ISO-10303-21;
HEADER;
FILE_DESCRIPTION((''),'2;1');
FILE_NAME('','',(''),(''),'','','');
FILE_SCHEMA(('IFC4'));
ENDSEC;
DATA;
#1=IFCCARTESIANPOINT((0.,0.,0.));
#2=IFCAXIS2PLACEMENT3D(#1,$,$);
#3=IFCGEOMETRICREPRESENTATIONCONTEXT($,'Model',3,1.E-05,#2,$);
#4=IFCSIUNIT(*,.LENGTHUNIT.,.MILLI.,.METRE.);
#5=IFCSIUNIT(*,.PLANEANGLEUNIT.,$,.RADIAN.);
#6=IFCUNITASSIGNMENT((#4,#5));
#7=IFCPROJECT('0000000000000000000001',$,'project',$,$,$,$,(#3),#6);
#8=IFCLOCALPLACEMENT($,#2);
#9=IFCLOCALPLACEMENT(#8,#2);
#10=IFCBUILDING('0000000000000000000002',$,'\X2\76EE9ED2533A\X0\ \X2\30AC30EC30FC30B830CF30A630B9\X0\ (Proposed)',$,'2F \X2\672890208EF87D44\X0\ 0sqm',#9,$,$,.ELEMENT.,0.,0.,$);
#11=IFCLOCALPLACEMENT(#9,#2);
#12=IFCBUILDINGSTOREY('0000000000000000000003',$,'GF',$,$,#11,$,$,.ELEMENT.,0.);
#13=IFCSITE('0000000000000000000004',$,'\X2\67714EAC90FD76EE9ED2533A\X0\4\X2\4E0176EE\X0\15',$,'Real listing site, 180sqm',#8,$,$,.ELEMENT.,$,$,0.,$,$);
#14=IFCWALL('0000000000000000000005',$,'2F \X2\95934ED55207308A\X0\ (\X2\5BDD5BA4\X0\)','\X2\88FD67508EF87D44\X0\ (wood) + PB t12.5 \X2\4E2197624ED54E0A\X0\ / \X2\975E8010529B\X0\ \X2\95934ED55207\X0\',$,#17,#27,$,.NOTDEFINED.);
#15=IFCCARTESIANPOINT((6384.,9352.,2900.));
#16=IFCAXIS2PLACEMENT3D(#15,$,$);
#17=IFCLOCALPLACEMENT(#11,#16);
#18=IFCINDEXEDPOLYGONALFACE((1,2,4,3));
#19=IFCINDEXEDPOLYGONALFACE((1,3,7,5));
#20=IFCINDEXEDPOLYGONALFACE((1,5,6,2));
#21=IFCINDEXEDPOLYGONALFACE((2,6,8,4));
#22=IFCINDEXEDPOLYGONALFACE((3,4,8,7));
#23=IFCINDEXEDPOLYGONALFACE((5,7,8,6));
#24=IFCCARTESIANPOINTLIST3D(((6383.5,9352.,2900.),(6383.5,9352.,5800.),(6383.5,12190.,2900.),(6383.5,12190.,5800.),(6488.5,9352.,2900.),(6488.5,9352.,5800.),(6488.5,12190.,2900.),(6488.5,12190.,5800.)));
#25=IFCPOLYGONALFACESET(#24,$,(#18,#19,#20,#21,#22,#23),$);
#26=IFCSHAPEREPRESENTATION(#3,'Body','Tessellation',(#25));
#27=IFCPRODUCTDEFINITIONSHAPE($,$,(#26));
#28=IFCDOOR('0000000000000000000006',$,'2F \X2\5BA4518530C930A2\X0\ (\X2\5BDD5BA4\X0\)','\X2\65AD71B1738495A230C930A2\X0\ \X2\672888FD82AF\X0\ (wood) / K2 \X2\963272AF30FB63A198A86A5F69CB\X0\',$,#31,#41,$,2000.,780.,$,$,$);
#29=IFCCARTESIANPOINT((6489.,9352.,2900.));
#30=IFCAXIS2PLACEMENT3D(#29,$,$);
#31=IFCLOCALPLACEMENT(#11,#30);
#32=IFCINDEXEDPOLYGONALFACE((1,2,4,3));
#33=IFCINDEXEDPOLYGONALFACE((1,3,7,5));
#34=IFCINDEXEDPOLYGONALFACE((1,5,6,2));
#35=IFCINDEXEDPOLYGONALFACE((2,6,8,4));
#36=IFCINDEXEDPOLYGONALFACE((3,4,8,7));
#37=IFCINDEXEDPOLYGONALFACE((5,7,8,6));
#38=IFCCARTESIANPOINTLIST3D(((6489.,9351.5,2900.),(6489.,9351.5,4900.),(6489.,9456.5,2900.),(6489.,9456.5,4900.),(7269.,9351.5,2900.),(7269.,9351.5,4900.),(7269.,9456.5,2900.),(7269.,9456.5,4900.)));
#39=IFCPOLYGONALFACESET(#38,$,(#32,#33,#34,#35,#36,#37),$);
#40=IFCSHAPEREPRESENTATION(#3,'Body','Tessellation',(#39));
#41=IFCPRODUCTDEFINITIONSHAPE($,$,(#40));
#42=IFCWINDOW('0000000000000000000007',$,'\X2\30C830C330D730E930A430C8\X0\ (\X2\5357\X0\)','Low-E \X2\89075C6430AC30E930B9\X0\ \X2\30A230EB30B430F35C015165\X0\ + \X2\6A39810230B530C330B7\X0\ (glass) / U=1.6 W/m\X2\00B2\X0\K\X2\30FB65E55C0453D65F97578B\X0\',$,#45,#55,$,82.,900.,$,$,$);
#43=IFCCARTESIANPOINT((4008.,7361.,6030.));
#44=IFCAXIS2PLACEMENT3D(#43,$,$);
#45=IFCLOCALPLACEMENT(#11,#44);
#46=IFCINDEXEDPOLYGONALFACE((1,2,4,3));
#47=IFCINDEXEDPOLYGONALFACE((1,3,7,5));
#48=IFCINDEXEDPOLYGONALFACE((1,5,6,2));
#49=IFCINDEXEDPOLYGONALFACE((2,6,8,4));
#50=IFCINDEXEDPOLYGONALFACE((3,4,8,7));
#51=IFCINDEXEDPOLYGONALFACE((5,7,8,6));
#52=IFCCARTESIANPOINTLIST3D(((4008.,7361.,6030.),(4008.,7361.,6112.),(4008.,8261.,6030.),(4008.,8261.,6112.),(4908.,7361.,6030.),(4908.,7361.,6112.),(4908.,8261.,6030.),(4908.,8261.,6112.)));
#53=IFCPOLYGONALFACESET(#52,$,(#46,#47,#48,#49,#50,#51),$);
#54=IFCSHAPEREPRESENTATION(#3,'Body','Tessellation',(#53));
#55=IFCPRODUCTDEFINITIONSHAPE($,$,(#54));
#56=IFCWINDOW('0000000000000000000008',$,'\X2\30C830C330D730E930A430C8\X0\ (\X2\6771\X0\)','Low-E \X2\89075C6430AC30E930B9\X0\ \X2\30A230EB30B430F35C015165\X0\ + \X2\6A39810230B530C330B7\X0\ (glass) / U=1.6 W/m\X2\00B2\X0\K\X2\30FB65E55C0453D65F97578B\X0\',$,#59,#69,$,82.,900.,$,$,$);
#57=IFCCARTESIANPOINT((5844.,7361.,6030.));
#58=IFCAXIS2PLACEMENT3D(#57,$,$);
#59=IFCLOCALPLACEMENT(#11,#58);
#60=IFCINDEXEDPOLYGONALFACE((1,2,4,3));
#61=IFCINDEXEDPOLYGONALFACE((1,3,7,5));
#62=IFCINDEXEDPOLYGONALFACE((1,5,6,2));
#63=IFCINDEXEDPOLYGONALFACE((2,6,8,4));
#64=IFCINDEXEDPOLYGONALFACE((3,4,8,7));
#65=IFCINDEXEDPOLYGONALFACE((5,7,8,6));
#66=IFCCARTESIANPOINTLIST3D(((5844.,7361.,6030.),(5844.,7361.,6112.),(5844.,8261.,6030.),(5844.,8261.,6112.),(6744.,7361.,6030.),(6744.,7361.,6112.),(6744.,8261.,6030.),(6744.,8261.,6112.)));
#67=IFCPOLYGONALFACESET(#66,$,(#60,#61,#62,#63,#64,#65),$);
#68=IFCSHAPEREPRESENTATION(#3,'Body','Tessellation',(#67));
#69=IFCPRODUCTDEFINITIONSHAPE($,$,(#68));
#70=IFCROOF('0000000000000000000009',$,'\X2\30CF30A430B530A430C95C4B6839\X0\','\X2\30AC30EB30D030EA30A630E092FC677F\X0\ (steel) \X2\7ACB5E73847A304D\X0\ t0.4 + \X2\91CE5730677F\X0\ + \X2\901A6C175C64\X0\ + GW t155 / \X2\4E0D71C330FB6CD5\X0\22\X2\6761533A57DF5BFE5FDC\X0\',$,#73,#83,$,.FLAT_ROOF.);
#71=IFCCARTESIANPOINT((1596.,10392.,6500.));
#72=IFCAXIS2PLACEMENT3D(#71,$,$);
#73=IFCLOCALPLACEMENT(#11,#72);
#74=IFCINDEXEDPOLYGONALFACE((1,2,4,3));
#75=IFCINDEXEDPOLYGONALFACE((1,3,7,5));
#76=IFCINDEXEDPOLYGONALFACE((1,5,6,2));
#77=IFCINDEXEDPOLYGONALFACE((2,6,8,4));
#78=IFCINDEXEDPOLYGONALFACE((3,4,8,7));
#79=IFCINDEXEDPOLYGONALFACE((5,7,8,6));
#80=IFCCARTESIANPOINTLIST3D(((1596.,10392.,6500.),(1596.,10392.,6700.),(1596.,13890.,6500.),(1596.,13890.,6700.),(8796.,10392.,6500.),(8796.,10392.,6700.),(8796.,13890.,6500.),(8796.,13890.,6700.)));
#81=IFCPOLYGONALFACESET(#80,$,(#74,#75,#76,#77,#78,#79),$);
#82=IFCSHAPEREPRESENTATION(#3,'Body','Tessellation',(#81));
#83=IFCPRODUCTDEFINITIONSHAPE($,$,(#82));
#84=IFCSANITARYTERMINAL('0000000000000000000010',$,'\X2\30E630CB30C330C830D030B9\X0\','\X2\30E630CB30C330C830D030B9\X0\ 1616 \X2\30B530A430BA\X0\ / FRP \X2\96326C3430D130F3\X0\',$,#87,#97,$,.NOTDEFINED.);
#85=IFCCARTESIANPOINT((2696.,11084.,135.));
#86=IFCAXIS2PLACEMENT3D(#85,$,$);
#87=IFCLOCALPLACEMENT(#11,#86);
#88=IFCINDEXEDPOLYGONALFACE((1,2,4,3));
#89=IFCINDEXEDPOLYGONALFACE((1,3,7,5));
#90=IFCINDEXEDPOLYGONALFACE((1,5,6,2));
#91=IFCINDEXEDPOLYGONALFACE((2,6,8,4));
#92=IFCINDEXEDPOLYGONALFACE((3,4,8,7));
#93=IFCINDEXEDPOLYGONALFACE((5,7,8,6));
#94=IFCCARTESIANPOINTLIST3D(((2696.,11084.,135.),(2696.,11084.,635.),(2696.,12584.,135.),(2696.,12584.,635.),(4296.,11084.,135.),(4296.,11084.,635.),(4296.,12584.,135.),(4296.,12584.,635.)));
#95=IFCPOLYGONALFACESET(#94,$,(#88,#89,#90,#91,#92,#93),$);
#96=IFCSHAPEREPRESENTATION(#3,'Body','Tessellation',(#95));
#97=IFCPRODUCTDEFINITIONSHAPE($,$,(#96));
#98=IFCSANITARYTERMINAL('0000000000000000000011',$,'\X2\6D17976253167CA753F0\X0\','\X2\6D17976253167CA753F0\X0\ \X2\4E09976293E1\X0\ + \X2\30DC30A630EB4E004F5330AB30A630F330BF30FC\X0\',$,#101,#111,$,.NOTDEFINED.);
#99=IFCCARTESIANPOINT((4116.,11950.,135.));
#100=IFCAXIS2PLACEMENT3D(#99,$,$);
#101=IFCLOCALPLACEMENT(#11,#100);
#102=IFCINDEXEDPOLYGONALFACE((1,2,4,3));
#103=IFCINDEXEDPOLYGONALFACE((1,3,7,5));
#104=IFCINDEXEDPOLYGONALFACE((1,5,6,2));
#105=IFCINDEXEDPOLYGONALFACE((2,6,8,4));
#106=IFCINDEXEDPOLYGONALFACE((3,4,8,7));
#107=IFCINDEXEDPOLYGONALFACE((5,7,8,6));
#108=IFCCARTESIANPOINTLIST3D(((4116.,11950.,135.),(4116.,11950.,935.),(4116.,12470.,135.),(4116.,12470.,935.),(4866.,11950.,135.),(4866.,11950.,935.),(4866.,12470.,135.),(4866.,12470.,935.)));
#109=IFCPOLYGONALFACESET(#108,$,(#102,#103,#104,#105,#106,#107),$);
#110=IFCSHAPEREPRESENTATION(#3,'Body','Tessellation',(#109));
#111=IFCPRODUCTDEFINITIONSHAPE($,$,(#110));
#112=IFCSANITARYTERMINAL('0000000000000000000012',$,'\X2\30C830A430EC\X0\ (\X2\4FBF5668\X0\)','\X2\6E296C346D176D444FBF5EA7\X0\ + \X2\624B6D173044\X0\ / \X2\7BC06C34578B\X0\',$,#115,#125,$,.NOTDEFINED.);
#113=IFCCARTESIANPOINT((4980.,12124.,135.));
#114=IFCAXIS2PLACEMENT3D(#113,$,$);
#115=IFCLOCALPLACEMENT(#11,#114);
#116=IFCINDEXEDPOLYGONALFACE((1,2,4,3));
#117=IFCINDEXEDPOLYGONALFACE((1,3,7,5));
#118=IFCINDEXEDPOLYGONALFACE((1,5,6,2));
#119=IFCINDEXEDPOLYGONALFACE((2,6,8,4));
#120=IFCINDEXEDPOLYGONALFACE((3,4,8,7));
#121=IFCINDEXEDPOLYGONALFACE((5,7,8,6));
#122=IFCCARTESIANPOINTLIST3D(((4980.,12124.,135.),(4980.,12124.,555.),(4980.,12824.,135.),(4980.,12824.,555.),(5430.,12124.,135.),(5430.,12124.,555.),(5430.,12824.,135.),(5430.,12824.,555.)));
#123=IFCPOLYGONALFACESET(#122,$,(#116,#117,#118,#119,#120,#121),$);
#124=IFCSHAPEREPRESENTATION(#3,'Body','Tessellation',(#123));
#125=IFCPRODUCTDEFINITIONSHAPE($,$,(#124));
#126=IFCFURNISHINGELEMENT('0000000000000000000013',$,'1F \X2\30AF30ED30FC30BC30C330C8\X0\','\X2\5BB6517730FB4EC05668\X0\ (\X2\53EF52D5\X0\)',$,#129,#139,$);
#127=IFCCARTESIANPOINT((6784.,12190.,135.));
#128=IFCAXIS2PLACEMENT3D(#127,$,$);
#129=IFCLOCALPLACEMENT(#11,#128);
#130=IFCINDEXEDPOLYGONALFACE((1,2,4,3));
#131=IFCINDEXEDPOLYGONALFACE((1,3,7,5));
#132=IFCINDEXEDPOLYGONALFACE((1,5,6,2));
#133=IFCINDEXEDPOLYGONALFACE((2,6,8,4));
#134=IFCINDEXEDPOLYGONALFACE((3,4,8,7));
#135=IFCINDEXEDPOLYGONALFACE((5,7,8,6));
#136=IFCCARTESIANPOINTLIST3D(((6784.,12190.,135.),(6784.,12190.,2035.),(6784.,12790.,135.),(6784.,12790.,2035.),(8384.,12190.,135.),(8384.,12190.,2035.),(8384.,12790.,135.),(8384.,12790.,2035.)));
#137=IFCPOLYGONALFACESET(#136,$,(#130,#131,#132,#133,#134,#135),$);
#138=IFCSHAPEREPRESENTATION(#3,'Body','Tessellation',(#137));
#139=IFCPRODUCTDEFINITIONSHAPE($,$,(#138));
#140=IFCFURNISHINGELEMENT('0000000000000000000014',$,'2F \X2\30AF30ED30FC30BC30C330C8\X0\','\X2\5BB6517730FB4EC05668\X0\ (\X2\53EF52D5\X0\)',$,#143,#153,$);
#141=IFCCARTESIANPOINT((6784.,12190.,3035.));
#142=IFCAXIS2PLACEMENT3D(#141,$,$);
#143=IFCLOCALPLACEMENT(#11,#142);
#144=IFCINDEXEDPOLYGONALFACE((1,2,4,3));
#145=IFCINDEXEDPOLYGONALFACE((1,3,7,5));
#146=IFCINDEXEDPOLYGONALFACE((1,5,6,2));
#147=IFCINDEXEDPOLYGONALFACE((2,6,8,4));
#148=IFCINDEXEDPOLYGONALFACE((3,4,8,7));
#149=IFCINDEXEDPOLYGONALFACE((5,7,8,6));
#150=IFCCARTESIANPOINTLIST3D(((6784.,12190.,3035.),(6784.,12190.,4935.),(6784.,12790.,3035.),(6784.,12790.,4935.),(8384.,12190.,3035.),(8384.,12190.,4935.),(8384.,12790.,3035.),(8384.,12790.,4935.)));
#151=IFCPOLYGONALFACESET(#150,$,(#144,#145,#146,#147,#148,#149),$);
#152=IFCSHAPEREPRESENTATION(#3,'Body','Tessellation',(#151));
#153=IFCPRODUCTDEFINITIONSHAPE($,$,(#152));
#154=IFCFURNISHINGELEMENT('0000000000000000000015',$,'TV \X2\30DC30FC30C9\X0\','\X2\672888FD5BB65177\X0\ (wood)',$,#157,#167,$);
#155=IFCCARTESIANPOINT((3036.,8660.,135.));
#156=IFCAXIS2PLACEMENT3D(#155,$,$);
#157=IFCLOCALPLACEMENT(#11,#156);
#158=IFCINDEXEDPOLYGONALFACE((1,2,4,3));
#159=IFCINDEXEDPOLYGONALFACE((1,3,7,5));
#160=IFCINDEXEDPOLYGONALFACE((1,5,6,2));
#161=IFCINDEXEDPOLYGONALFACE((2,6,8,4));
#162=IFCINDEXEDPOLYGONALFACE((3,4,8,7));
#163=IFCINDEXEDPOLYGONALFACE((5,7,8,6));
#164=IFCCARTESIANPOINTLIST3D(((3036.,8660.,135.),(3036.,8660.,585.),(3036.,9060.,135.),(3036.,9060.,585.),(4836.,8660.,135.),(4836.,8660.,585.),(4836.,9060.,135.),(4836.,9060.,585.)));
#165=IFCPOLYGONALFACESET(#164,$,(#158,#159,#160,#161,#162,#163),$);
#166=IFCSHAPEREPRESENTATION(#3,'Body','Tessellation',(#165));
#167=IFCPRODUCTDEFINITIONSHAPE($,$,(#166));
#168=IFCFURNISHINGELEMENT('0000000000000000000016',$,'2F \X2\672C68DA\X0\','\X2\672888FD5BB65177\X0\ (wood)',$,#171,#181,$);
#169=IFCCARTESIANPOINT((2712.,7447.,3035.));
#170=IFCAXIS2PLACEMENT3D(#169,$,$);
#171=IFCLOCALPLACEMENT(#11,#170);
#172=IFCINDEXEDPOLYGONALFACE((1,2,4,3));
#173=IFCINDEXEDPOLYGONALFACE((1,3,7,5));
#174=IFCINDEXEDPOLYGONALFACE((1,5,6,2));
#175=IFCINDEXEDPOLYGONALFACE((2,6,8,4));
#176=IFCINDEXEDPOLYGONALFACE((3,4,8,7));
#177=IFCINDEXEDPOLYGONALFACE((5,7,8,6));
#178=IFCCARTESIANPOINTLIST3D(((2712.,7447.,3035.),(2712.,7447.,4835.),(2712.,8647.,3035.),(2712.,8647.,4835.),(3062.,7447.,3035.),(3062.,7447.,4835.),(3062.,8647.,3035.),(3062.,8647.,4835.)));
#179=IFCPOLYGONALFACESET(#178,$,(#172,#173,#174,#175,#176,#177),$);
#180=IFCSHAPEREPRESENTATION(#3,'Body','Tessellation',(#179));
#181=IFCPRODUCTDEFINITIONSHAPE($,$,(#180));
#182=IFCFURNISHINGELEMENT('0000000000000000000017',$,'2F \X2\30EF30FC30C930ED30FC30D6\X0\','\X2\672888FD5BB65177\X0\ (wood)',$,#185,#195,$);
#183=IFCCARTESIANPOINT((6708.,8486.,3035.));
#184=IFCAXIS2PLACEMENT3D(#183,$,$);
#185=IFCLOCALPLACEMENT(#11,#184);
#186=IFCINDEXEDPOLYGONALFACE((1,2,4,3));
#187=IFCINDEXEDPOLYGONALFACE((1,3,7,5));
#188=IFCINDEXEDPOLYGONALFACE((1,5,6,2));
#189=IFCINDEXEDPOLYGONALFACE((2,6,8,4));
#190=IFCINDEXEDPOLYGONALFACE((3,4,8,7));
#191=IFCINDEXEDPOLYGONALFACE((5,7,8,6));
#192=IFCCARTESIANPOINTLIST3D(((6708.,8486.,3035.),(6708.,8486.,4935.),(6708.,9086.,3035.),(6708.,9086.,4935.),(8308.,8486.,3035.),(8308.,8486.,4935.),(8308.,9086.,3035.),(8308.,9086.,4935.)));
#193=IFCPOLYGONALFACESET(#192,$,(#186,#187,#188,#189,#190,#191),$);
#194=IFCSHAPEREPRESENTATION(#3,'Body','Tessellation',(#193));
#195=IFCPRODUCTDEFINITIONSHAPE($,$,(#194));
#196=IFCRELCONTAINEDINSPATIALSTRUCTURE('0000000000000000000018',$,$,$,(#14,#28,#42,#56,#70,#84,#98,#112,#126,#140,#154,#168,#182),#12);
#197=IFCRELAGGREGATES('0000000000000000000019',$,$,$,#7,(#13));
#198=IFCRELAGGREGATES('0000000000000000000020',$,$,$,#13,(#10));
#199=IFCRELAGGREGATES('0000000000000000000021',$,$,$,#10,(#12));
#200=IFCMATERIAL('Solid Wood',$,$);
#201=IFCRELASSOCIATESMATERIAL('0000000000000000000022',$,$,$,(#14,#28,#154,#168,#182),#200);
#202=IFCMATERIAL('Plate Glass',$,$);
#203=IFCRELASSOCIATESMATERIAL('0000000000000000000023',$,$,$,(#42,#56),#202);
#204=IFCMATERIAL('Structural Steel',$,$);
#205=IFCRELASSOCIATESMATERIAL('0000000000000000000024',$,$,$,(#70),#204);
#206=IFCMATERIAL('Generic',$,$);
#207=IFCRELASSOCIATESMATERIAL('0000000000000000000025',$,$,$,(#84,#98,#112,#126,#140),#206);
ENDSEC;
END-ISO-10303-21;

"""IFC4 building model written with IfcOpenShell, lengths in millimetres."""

from ifc_helpers import new_model, si_unit, frame, frame_2d, origin, place, context, project, spatial, rectangle, extrude, material, element, save


model = new_model("IFC4")

# Units and contexts
model_context = context("Model", 3, precision=1e-05, world=origin())
ifc_project = project(units=[si_unit("LENGTHUNIT", "METRE", prefix="MILLI"), si_unit("PLANEANGLEUNIT", "RADIAN")], contexts=[model_context])

# Site, building, storey
site_placement = place(None, origin())
site = spatial("IfcSite", under=ifc_project, at=site_placement, Name="東京都目黒区4丁目15", ObjectType="Real listing site, 180sqm", CompositionType="ELEMENT", RefElevation=0.0)
building_placement = place(site_placement, origin())
building = spatial("IfcBuilding", under=site, at=building_placement, Name="目黒区 ガレージハウス (Proposed)", ObjectType="2F 木造軸組 0sqm", CompositionType="ELEMENT", ElevationOfRefHeight=0.0, ElevationOfTerrain=0.0)
storey_placement = place(building_placement, origin())
storey = spatial("IfcBuildingStorey", under=building, at=storey_placement, Name="GF", CompositionType="ELEMENT", Elevation=0.0)

# Shared definitions
ifc_material_1 = material(Name="Solid Wood")
ifc_material_2 = material(Name="Plate Glass")

# Wall
wall_1_placement = place(storey_placement, frame((6384.0, 9352.0, 2900.0)))
element("IfcWall", 1, at=wall_1_placement, inside=storey, material=ifc_material_1, Name="2F 間仕切り (寝室)", Description="製材軸組 (wood) + PB t12.5 両面仕上 / 非耐力 間仕切", PredefinedType="NOTDEFINED", context=model_context, shape_type="SweptSolid", body=[
    extrude(rectangle(XDim=105.0, YDim=2838.0, at=frame_2d((52.0, 1419.0))), frame((6384.0, 9352.0, 2900.0)), (0.0, 0.0, 1.0), 2900.0),
])

# Door
door_1_placement = place(storey_placement, frame((6489.0, 9352.0, 2900.0)))
element("IfcDoor", 2, at=door_1_placement, inside=storey, material=ifc_material_1, Name="2F 室内ドア (寝室)", Description="断熱玄関ドア 木製芯 (wood) / K2 防犯・採風機構", OverallHeight=2000.0, OverallWidth=780.0, context=model_context, shape_type="SweptSolid", body=[
    extrude(rectangle(XDim=780.0, YDim=105.0, at=frame_2d((390.0, 52.0))), frame((6489.0, 9352.0, 2900.0)), (0.0, 0.0, 1.0), 2000.0),
])

# Windows
window_1_placement = place(storey_placement, frame((4008.0, 7361.0, 6030.0)))
element("IfcWindow", 3, at=window_1_placement, inside=storey, material=ifc_material_2, Name="トップライト (南)", Description="Low-E 複層ガラス アルゴン封入 + 樹脂サッシ (glass) / U=1.6 W/m²K・日射取得型", OverallHeight=82.0, OverallWidth=900.0, context=model_context, shape_type="SweptSolid", body=[
    extrude(rectangle(XDim=900.0, YDim=900.0, at=frame_2d((450.0, 450.0))), frame((4008.0, 7361.0, 6030.0)), (0.0, 0.0, 1.0), 82.0),
])
window_2_placement = place(storey_placement, frame((5844.0, 7361.0, 6030.0)))
element("IfcWindow", 4, at=window_2_placement, inside=storey, material=ifc_material_2, Name="トップライト (東)", Description="Low-E 複層ガラス アルゴン封入 + 樹脂サッシ (glass) / U=1.6 W/m²K・日射取得型", OverallHeight=82.0, OverallWidth=900.0, context=model_context, shape_type="SweptSolid", body=[
    extrude(rectangle(XDim=900.0, YDim=900.0, at=frame_2d((450.0, 450.0))), frame((5844.0, 7361.0, 6030.0)), (0.0, 0.0, 1.0), 82.0),
])

# Roof
ifc_material_3 = material(Name="Structural Steel")
roof_placement = place(storey_placement, frame((1596.0, 10392.0, 6500.0)))
element("IfcRoof", 5, at=roof_placement, inside=storey, material=ifc_material_3, Name="ハイサイド屋根", Description="ガルバリウム鋼板 (steel) 立平葺き t0.4 + 野地板 + 通気層 + GW t155 / 不燃・法22条区域対応", PredefinedType="FLAT_ROOF", context=model_context, shape_type="SweptSolid", body=[
    extrude(rectangle(XDim=7200.0, YDim=3498.0, at=frame_2d((3600.0, 1749.0))), frame((1596.0, 10392.0, 6500.0)), (0.0, 0.0, 1.0), 200.0),
])

# Sanitary terminals
ifc_material_4 = material(Name="Generic")
sanitary_terminal_1_placement = place(storey_placement, frame((2696.0, 11084.0, 135.0)))
element("IfcSanitaryTerminal", 6, at=sanitary_terminal_1_placement, inside=storey, material=ifc_material_4, Name="ユニットバス", Description="ユニットバス 1616 サイズ / FRP 防水パン", PredefinedType="NOTDEFINED", context=model_context, shape_type="SweptSolid", body=[
    extrude(rectangle(XDim=1600.0, YDim=1500.0, at=frame_2d((800.0, 750.0))), frame((2696.0, 11084.0, 135.0)), (0.0, 0.0, 1.0), 500.0),
])
sanitary_terminal_2_placement = place(storey_placement, frame((4116.0, 11950.0, 135.0)))
element("IfcSanitaryTerminal", 7, at=sanitary_terminal_2_placement, inside=storey, material=ifc_material_4, Name="洗面化粧台", Description="洗面化粧台 三面鏡 + ボウル一体カウンター", PredefinedType="NOTDEFINED", context=model_context, shape_type="SweptSolid", body=[
    extrude(rectangle(XDim=750.0, YDim=520.0, at=frame_2d((375.0, 260.0))), frame((4116.0, 11950.0, 135.0)), (0.0, 0.0, 1.0), 800.0),
])
sanitary_terminal_3_placement = place(storey_placement, frame((4980.0, 12124.0, 135.0)))
element("IfcSanitaryTerminal", 8, at=sanitary_terminal_3_placement, inside=storey, material=ifc_material_4, Name="トイレ (便器)", Description="温水洗浄便座 + 手洗い / 節水型", PredefinedType="NOTDEFINED", context=model_context, shape_type="SweptSolid", body=[
    extrude(rectangle(XDim=450.0, YDim=700.0, at=frame_2d((225.0, 350.0))), frame((4980.0, 12124.0, 135.0)), (0.0, 0.0, 1.0), 420.0),
])

# Furnishing elements
furnishing_1_placement = place(storey_placement, frame((6784.0, 12190.0, 135.0)))
element("IfcFurnishingElement", 9, at=furnishing_1_placement, inside=storey, material=ifc_material_4, Name="1F クローゼット", Description="家具・什器 (可動)", context=model_context, shape_type="SweptSolid", body=[
    extrude(rectangle(XDim=1600.0, YDim=600.0, at=frame_2d((800.0, 300.0))), frame((6784.0, 12190.0, 135.0)), (0.0, 0.0, 1.0), 1900.0),
])
furnishing_2_placement = place(storey_placement, frame((6784.0, 12190.0, 3035.0)))
element("IfcFurnishingElement", 10, at=furnishing_2_placement, inside=storey, material=ifc_material_4, Name="2F クローゼット", Description="家具・什器 (可動)", context=model_context, shape_type="SweptSolid", body=[
    extrude(rectangle(XDim=1600.0, YDim=600.0, at=frame_2d((800.0, 300.0))), frame((6784.0, 12190.0, 3035.0)), (0.0, 0.0, 1.0), 1900.0),
])
furnishing_3_placement = place(storey_placement, frame((3036.0, 8660.0, 135.0)))
element("IfcFurnishingElement", 11, at=furnishing_3_placement, inside=storey, material=ifc_material_1, Name="TV ボード", Description="木製家具 (wood)", context=model_context, shape_type="SweptSolid", body=[
    extrude(rectangle(XDim=1800.0, YDim=400.0, at=frame_2d((900.0, 200.0))), frame((3036.0, 8660.0, 135.0)), (0.0, 0.0, 1.0), 450.0),
])
furnishing_4_placement = place(storey_placement, frame((2712.0, 7447.0, 3035.0)))
element("IfcFurnishingElement", 12, at=furnishing_4_placement, inside=storey, material=ifc_material_1, Name="2F 本棚", Description="木製家具 (wood)", context=model_context, shape_type="SweptSolid", body=[
    extrude(rectangle(XDim=350.0, YDim=1200.0, at=frame_2d((175.0, 600.0))), frame((2712.0, 7447.0, 3035.0)), (0.0, 0.0, 1.0), 1800.0),
])
furnishing_5_placement = place(storey_placement, frame((6708.0, 8486.0, 3035.0)))
element("IfcFurnishingElement", 13, at=furnishing_5_placement, inside=storey, material=ifc_material_1, Name="2F ワードローブ", Description="木製家具 (wood)", context=model_context, shape_type="SweptSolid", body=[
    extrude(rectangle(XDim=1600.0, YDim=600.0, at=frame_2d((800.0, 300.0))), frame((6708.0, 8486.0, 3035.0)), (0.0, 0.0, 1.0), 1900.0),
])

save(model, "model.ifc")
